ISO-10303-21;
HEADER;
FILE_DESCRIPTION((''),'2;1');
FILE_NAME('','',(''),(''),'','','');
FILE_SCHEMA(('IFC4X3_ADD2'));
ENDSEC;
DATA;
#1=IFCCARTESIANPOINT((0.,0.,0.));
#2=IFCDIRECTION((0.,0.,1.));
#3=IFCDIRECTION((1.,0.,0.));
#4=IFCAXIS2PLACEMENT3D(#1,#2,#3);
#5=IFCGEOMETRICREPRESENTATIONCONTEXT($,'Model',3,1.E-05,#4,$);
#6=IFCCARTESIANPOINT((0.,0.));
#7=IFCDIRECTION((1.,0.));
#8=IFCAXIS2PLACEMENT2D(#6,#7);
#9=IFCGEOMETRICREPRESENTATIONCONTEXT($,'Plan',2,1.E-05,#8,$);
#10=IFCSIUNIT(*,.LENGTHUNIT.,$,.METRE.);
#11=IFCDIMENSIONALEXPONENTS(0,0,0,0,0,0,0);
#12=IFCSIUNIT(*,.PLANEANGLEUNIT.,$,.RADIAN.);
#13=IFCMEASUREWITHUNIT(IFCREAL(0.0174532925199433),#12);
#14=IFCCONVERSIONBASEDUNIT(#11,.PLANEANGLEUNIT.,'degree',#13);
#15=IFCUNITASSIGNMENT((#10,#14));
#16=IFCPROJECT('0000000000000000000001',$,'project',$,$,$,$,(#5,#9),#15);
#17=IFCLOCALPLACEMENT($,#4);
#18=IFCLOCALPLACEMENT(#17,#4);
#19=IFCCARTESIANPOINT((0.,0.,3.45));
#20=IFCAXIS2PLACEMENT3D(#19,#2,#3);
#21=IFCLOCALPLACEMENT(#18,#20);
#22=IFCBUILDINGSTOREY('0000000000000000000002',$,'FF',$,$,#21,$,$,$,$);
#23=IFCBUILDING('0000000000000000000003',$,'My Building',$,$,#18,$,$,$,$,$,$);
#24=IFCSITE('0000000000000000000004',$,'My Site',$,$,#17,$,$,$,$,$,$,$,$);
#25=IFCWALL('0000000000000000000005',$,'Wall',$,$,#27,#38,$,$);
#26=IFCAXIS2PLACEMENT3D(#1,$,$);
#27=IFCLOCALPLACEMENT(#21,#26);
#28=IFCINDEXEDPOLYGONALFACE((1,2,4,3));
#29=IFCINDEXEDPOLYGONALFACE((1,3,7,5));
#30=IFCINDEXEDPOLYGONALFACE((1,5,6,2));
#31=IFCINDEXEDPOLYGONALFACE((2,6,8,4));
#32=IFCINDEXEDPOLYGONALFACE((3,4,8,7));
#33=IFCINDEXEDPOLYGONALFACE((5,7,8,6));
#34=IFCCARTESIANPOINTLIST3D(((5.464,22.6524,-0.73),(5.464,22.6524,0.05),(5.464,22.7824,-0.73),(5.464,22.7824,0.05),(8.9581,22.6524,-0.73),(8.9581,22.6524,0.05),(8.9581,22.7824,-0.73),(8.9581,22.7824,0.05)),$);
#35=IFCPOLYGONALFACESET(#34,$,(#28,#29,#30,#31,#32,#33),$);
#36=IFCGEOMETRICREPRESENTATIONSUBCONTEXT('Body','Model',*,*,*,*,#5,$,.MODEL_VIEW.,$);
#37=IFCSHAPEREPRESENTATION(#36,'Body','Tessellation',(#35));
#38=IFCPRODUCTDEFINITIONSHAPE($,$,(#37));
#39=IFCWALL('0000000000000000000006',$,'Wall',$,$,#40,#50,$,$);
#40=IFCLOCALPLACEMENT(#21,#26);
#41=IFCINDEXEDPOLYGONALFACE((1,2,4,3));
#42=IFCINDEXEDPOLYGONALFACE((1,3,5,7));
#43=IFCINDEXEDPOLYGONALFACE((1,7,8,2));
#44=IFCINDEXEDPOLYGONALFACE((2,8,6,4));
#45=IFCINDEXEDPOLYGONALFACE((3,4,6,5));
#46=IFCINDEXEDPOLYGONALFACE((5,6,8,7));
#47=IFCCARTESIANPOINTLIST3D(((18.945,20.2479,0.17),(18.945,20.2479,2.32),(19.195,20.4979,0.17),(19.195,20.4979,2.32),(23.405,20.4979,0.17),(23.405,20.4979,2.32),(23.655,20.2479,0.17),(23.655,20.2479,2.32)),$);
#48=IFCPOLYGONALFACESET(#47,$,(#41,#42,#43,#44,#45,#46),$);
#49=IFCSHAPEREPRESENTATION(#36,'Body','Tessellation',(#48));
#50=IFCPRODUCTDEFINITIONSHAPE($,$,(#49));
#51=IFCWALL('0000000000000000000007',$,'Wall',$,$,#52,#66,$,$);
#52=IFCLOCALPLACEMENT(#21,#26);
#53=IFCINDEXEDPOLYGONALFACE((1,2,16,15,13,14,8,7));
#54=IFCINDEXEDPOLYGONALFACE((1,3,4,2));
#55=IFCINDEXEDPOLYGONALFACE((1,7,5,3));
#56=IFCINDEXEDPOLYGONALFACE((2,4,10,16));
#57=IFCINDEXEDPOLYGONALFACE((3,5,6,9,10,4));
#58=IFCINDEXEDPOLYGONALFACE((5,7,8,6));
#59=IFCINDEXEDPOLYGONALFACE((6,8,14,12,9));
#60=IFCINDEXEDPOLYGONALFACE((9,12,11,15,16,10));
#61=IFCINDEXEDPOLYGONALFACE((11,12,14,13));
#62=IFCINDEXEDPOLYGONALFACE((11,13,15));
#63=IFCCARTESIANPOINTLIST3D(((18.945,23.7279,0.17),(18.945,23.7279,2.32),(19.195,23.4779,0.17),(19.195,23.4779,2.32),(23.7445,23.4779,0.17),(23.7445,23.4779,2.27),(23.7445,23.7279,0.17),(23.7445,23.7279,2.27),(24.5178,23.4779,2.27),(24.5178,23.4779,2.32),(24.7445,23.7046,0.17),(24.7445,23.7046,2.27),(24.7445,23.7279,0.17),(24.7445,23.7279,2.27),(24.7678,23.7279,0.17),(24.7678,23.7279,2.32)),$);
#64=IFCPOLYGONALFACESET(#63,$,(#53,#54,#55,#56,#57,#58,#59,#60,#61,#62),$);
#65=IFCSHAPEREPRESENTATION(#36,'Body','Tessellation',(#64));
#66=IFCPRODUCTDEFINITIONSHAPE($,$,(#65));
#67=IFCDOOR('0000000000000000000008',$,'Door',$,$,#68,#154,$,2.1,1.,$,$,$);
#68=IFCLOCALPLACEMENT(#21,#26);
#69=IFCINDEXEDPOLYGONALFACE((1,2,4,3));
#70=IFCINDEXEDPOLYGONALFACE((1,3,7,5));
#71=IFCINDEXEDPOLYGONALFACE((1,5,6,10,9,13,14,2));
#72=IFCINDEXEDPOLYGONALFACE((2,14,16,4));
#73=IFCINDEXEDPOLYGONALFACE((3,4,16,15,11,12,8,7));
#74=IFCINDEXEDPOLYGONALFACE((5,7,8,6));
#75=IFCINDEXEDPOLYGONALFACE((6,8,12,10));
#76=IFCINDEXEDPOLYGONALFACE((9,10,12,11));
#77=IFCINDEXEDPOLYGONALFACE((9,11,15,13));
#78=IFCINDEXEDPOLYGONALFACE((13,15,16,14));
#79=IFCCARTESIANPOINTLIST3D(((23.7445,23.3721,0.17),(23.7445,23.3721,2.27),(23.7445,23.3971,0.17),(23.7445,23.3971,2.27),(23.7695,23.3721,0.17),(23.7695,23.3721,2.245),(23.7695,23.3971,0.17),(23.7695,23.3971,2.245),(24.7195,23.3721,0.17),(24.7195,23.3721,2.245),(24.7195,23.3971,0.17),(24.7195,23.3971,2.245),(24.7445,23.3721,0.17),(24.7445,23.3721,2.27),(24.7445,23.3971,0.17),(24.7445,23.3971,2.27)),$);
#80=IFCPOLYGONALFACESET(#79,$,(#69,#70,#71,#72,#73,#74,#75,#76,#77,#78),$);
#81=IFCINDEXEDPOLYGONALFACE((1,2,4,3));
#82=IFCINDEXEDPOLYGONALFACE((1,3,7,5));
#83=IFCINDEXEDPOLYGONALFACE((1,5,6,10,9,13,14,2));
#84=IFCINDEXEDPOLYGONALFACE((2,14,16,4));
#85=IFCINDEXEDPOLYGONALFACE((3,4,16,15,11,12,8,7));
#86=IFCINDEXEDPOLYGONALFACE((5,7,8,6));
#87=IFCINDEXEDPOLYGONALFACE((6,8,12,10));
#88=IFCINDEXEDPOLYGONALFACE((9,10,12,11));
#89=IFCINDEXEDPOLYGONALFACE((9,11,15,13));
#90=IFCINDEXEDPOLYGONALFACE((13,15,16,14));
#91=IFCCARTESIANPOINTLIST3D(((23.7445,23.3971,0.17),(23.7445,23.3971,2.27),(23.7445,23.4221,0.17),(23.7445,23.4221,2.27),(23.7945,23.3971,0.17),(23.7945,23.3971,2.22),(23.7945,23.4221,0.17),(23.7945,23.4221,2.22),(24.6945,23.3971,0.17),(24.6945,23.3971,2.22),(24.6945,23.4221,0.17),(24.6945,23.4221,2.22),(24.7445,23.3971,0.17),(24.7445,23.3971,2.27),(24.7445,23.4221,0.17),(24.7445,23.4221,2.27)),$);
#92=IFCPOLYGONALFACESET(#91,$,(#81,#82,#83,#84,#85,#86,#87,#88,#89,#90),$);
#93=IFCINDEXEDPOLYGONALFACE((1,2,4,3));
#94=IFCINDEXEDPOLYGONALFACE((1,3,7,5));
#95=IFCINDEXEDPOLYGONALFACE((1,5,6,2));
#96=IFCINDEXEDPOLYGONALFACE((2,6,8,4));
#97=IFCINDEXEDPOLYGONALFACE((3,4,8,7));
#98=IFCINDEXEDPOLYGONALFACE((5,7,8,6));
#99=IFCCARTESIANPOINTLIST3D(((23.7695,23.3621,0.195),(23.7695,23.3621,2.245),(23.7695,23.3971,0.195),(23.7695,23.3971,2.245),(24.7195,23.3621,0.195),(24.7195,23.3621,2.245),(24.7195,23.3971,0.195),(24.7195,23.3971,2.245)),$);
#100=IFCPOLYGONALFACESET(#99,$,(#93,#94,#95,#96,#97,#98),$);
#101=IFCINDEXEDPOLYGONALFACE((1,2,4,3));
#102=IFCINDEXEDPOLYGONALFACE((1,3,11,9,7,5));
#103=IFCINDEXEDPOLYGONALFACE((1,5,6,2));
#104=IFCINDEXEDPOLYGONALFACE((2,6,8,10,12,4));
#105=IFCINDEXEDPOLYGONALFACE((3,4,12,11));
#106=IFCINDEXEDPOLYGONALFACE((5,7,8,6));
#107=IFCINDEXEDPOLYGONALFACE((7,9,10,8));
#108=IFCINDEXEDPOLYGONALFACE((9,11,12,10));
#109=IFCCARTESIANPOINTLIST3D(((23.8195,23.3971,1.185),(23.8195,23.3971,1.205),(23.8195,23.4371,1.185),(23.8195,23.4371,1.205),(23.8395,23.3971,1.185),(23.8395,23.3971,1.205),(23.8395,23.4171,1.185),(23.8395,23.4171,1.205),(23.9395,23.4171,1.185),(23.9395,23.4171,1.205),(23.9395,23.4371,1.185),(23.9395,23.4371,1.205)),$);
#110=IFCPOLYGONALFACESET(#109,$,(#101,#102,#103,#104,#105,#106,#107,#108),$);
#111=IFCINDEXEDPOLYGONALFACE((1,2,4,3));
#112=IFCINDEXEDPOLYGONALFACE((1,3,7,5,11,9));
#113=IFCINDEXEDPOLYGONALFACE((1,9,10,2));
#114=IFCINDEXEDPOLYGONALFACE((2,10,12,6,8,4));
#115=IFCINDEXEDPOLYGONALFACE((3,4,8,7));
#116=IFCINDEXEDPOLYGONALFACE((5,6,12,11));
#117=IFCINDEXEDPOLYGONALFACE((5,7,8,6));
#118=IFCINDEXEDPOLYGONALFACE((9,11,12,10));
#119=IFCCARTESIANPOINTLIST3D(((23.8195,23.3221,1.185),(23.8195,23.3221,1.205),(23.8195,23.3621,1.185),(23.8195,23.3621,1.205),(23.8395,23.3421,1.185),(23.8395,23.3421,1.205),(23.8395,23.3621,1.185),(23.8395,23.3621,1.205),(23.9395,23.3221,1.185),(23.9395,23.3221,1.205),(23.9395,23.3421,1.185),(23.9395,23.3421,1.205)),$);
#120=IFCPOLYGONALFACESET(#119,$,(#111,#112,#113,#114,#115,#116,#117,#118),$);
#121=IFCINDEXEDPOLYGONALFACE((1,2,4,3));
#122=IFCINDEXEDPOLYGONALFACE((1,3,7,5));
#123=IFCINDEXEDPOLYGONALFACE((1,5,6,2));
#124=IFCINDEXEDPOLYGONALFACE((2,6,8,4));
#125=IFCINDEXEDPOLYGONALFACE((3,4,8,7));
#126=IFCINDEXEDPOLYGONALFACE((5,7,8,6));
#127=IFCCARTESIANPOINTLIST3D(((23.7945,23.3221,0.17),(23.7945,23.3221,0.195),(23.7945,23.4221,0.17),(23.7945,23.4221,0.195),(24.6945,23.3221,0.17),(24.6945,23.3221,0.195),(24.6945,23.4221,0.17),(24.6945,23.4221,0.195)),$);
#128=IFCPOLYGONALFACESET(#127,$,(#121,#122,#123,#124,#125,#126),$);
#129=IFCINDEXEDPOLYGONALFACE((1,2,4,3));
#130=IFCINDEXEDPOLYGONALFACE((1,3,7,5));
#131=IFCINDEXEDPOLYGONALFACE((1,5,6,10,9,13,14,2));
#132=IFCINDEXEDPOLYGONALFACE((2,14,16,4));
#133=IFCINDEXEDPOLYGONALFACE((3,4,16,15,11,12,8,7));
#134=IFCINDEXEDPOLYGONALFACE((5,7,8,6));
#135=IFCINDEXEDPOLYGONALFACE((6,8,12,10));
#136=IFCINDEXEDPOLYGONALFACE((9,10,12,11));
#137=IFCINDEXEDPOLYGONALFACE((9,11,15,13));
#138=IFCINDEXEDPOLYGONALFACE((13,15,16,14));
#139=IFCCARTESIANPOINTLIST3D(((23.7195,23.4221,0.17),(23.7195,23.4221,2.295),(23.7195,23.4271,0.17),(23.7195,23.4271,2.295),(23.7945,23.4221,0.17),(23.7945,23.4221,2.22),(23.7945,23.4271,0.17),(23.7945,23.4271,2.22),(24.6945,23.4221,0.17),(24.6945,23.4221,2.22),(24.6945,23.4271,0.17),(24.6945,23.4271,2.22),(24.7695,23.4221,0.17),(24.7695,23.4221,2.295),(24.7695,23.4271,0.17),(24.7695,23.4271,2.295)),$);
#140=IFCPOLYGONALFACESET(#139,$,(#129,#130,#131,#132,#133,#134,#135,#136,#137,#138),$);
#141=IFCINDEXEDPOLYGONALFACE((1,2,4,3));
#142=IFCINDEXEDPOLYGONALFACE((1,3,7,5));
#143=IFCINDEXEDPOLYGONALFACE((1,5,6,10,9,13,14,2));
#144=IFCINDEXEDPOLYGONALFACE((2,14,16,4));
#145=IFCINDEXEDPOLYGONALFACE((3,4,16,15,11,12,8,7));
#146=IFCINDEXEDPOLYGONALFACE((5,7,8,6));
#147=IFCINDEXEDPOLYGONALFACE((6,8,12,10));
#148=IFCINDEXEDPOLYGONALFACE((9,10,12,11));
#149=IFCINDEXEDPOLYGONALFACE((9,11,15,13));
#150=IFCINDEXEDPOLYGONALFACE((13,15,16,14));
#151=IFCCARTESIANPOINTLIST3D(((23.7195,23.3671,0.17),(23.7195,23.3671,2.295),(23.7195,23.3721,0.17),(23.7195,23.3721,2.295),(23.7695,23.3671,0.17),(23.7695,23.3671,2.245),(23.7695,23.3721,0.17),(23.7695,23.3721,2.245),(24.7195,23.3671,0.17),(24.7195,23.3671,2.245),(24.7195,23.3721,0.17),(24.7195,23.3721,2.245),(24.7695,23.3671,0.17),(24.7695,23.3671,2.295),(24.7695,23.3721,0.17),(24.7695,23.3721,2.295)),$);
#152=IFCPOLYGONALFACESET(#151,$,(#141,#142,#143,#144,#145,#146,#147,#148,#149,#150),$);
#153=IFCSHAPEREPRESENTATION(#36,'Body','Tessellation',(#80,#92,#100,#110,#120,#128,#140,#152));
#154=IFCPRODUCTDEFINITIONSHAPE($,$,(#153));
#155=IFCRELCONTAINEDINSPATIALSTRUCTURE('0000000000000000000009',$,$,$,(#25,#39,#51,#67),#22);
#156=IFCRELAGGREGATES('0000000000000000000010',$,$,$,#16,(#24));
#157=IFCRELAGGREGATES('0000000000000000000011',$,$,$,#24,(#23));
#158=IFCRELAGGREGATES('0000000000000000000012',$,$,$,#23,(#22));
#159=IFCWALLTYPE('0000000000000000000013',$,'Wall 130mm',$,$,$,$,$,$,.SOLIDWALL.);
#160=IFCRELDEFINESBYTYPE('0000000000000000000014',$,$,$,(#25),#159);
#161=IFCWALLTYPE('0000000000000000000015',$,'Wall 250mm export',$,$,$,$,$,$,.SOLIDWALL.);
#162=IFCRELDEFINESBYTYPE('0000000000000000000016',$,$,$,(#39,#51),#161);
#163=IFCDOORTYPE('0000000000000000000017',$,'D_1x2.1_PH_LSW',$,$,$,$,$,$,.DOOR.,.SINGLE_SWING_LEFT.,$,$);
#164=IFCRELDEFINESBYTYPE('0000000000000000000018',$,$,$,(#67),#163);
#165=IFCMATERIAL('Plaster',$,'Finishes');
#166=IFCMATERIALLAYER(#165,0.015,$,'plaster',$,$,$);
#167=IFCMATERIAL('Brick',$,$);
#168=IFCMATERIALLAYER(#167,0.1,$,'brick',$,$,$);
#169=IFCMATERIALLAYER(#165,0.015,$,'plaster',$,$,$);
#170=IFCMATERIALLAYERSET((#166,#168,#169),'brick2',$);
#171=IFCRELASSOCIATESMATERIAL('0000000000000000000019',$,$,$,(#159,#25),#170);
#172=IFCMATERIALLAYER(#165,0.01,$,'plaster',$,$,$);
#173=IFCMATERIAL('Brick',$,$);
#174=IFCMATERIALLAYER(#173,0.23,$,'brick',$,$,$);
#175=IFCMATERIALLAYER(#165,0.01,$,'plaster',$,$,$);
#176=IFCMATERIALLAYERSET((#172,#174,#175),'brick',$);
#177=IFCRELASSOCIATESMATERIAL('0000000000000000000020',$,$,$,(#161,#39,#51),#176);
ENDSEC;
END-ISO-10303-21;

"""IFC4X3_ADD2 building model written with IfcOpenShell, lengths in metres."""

from ifc_helpers import new_model, entity, si_unit, converted_unit, frame, origin_with_axes, origin_2d_with_axis, place, context, subcontext, project, spatial, line, indexed_curve, outline, extrude, shape, source, transform, mapped, material, layer, layer_set, layer_usage, type_object, type_shapes, element, fill, save


model = new_model("IFC4X3_ADD2")

# Units and contexts
model_context = context("Model", 3, precision=1e-05, world=origin_with_axes())
plan_context = context("Plan", 2, precision=1e-05, world=origin_2d_with_axis())
body_context_1 = subcontext(model_context, "Body", "Model", "MODEL_VIEW")
body_context_2 = subcontext(plan_context, "Body", "Plan", "PLAN_VIEW")
ifc_project = project(units=[si_unit("LENGTHUNIT", "METRE"), converted_unit("PLANEANGLEUNIT", "degree", entity("IfcReal", 0.0174532925199433), si_unit("PLANEANGLEUNIT", "RADIAN"), dimensions=[0, 0, 0, 0, 0, 0, 0])], contexts=[model_context, plan_context])

# Site, building, storey
site_placement = place(None, origin_with_axes())
site = spatial("IfcSite", under=ifc_project, at=site_placement, Name="My Site")
building_placement = place(site_placement, origin_with_axes())
building = spatial("IfcBuilding", under=site, at=building_placement, Name="My Building")
storey_placement = place(building_placement, frame((0.0, 0.0, 3.45), z_axis=(0.0, 0.0, 1.0), x_axis=(1.0, 0.0, 0.0)))
storey = spatial("IfcBuildingStorey", under=building, at=storey_placement, Name="FF")

# Walls
ifc_material_1 = material(Name="Plaster", Category="Finishes")
ifc_layer_1 = layer(ifc_material_1, 0.015, Name="plaster")
ifc_material_2 = material(Name="Brick")
ifc_layer_2 = layer(ifc_material_2, 0.1, Name="brick")
ifc_layer_3 = layer(ifc_material_1, 0.015, Name="plaster")
ifc_layer_set_1 = layer_set([ifc_layer_1, ifc_layer_2, ifc_layer_3], Name="brick2")
ifc_layer_usage_1 = layer_usage(ifc_layer_set_1, "AXIS2", "POSITIVE", 0.0)
wall_type_1 = type_object("IfcWallType", Name="Wall 130mm", PredefinedType="SOLIDWALL", material=ifc_layer_set_1)
wall_1_placement = place(storey_placement, frame((5.464, 22.6524, -0.73), z_axis=(0.0, 0.0, 1.0), x_axis=(1.0, 0.0, 0.0)))
element("IfcWall", 1, at=wall_1_placement, inside=storey, type_object=wall_type_1, material=ifc_layer_usage_1, Name="Wall", context=body_context_1, shape_type="SweptSolid", body=[
    extrude(outline(indexed_curve([(0.0, 0.0), (0.0, 0.13), (3.4941, 0.13), (3.4941, 0.0)], segments=[line(1, 2, 3, 4, 1)])), origin_with_axes(), (0.0, 0.0, 1.0), 0.78),
])
ifc_layer_4 = layer(ifc_material_1, 0.01, Name="plaster")
ifc_material_3 = material(Name="Brick")
ifc_layer_5 = layer(ifc_material_3, 0.23, Name="brick")
ifc_layer_6 = layer(ifc_material_1, 0.01, Name="plaster")
ifc_layer_set_2 = layer_set([ifc_layer_4, ifc_layer_5, ifc_layer_6], Name="brick")
ifc_layer_usage_2 = layer_usage(ifc_layer_set_2, "AXIS2", "POSITIVE", 0.0)
wall_type_2 = type_object("IfcWallType", Name="Wall 250mm export", PredefinedType="SOLIDWALL", material=ifc_layer_set_2)
wall_2_placement = place(storey_placement, frame((19.195, 20.2479, 0.17), z_axis=(0.0, 0.0, 1.0), x_axis=(1.0, 0.0, 0.0)))
element("IfcWall", 2, at=wall_2_placement, inside=storey, type_object=wall_type_2, material=ifc_layer_usage_2, Name="Wall", context=body_context_1, shape_type="SweptSolid", body=[
    extrude(outline(indexed_curve([(-0.25, 0.0), (0.0, 0.25), (4.21, 0.25), (4.46, 0.0)], segments=[line(1, 2, 3, 4, 1)])), origin_with_axes(), (0.0, 0.0, 1.0), 2.15),
])

# Wall, opening, door
ifc_layer_usage_3 = layer_usage(ifc_layer_set_2, "AXIS2", "POSITIVE", 0.0)
wall_3_placement = place(storey_placement, frame((19.195, 23.4779, 0.17), z_axis=(0.0, 0.0, 1.0), x_axis=(1.0, 0.0, 0.0)))
wall_3 = element("IfcWall", 3, at=wall_3_placement, inside=storey, type_object=wall_type_2, material=ifc_layer_usage_3, Name="Wall", context=body_context_1, shape_type="SweptSolid", body=[
    extrude(outline(indexed_curve([(0.0, 0.0), (-0.25, 0.25), (5.5728, 0.25), (5.3228, 0.0)], segments=[line(1, 2, 3, 4, 1)])), origin_with_axes(), (0.0, 0.0, 1.0), 2.15),
])
shared_shape_1 = source(origin_with_axes(), body_context_1, "Body", "SweptSolid", [
    extrude(outline(indexed_curve([(0.0, 0.0), (1.0, 0.0), (1.0, 2.1), (0.0, 2.1)], segments=[line(1, 2, 3, 4, 1)])), frame((0.0, -0.6, 0.0), z_axis=(0.0, -1.0, 0.0), x_axis=(1.0, 0.0, 0.0)), (0.0, 0.0, -1.0), 1.2),
])
opening_1_placement = place(wall_3_placement, frame((5.5495, 0.1742, 0.0), z_axis=(0.0, 0.0, 1.0), x_axis=(-1.0, 0.0, 0.0)))
opening_1 = element("IfcOpeningElement", 4, at=opening_1_placement, cuts=wall_3, PredefinedType="OPENING", context=body_context_1, shape_type="MappedRepresentation", body=[
    mapped(shared_shape_1, transform((0.0, 0.0, 0.0), x_axis=(1.0, 0.0, 0.0), y_axis=(0.0, 1.0, 0.0), z_axis=(0.0, 0.0, 1.0), scale=1.0)),
])
door_type_1 = type_object("IfcDoorType", Name="D_1x2.1_PH_LSW", OperationType="SINGLE_SWING_LEFT", PredefinedType="DOOR")
shared_shape_2 = source(origin_with_axes(), body_context_1, "Body", "SweptSolid", [
    extrude(outline(indexed_curve([(0.0, 0.0), (0.0, 2.1), (1.0, 2.1), (1.0, 0.0), (0.975, 0.0), (0.975, 2.075), (0.025, 2.075), (0.025, 0.0)], segments=[line(1, 2, 3, 4, 5, 6, 7, 8, 1)])), frame((0.0, 0.025, 0.0), z_axis=(0.0, -1.0, 0.0), x_axis=(1.0, 0.0, 0.0)), (0.0, 0.0, -1.0), 0.025),
    extrude(outline(indexed_curve([(0.0, 0.0), (0.0, 2.1), (1.0, 2.1), (1.0, 0.0), (0.95, 0.0), (0.95, 2.05), (0.05, 2.05), (0.05, 0.0)], segments=[line(1, 2, 3, 4, 5, 6, 7, 8, 1)])), frame((0.0, 0.0, 0.0), z_axis=(0.0, -1.0, 0.0), x_axis=(1.0, 0.0, 0.0)), (0.0, 0.0, -1.0), 0.025),
    extrude(outline(indexed_curve([(0.0, 0.0), (0.95, 0.0), (0.95, 0.035), (0.0, 0.035)], segments=[line(1, 2, 3, 4, 1)])), frame((0.025, 0.025, 0.025), z_axis=(0.0, 0.0, 1.0), x_axis=(1.0, 0.0, 0.0)), (0.0, 0.0, 1.0), 2.05),
    extrude(outline(indexed_curve([(0.0, 0.0), (0.0, -0.04), (-0.12, -0.04), (-0.12, -0.02), (-0.02, -0.02), (-0.02, 0.0)], segments=[line(1, 2, 3, 4, 5, 6, 1)])), frame((0.925, 0.025, 1.015), z_axis=(0.0, 0.0, 1.0), x_axis=(1.0, 0.0, 0.0)), (0.0, 0.0, 1.0), 0.02),
    extrude(outline(indexed_curve([(0.0, 0.0), (0.0, 0.04), (-0.12, 0.04), (-0.12, 0.02), (-0.02, 0.02), (-0.02, 0.0)], segments=[line(1, 2, 3, 4, 5, 6, 1)])), frame((0.925, 0.06, 1.015), z_axis=(0.0, 0.0, 1.0), x_axis=(1.0, 0.0, 0.0)), (0.0, 0.0, 1.0), 0.02),
    extrude(outline(indexed_curve([(0.0, 0.0), (0.9, 0.0), (0.9, 0.1), (0.0, 0.1)], segments=[line(1, 2, 3, 4, 1)])), frame((0.05, 0.0, 0.0), z_axis=(0.0, 0.0, 1.0), x_axis=(1.0, 0.0, 0.0)), (0.0, 0.0, 1.0), 0.025),
    extrude(outline(indexed_curve([(0.0, 0.0), (0.0, 2.125), (1.05, 2.125), (1.05, 0.0), (0.975, 0.0), (0.975, 2.05), (0.075, 2.05), (0.075, 0.0)], segments=[line(1, 2, 3, 4, 5, 6, 7, 8, 1)])), frame((-0.025, -0.005, 0.0), z_axis=(0.0, -1.0, 0.0), x_axis=(1.0, 0.0, 0.0)), (0.0, 0.0, -1.0), 0.005),
    extrude(outline(indexed_curve([(0.0, 0.0), (0.0, 2.125), (1.05, 2.125), (1.05, 0.0), (1.0, 0.0), (1.0, 2.075), (0.05, 2.075), (0.05, 0.0)], segments=[line(1, 2, 3, 4, 5, 6, 7, 8, 1)])), frame((-0.025, 0.05, 0.0), z_axis=(0.0, -1.0, 0.0), x_axis=(1.0, 0.0, 0.0)), (0.0, 0.0, -1.0), 0.005),
])
shared_shape_3 = source(origin_with_axes(), body_context_2, "Body", "Curve2D", [
    entity("IfcIndexedPolyCurve", entity("IfcCartesianPointList2D", [[0.0, 0.0], [0.0, 0.05], [0.025, 0.05], [0.025, 0.025], [0.05, 0.025], [0.05, 0.0]]), [entity("IfcLineIndex", [1, 2, 3, 4, 5, 6, 1])]),
    entity("IfcIndexedPolyCurve", entity("IfcCartesianPointList2D", [[1.0, 0.0], [1.0, 0.05], [0.975, 0.05], [0.975, 0.025], [0.95, 0.025], [0.95, 0.0]]), [entity("IfcLineIndex", [1, 2, 3, 4, 5, 6, 1])]),
    entity("IfcTrimmedCurve", entity("IfcEllipse", entity("IfcAxis2Placement2D", entity("IfcCartesianPoint", [0.06, 0.05]), entity("IfcDirection", [1.0, 0.0])), 0.915, 0.95), [entity("IfcCartesianPoint", [0.975, 0.05])], [entity("IfcCartesianPoint", [0.06, 1.0])], True, "CARTESIAN"),
    entity("IfcIndexedPolyCurve", entity("IfcCartesianPointList2D", [[0.025, 0.05], [0.06, 0.05], [0.06, 1.0], [0.025, 1.0]]), [entity("IfcLineIndex", [1, 2, 3, 4, 1])]),
])
type_shapes(door_type_1, [shared_shape_2, shared_shape_3])
door_1_placement = place(opening_1_placement, frame((0.0, 0.23, 0.0), z_axis=(0.0, 0.0, 1.0), x_axis=(1.0, 0.0, 0.0)))
door_1 = element("IfcDoor", 5, at=door_1_placement, inside=storey, type_object=door_type_1, Name="Door", OverallHeight=2.1, OverallWidth=1.0, shapes=[
    shape(body_context_1, "Body", "MappedRepresentation", [mapped(shared_shape_2, transform((0.0, 0.0, 0.0), x_axis=(1.0, 0.0, 0.0), y_axis=(0.0, 1.0, 0.0), z_axis=(0.0, 0.0, 1.0), scale=1.0))]),
    shape(body_context_2, "Body", "MappedRepresentation", [mapped(shared_shape_3, transform((0.0, 0.0, 0.0), x_axis=(1.0, 0.0, 0.0), y_axis=(0.0, 1.0, 0.0), z_axis=(0.0, 0.0, 1.0), scale=1.0))]),
])
fill(opening_1, door_1)

save(model, "model.ifc")
